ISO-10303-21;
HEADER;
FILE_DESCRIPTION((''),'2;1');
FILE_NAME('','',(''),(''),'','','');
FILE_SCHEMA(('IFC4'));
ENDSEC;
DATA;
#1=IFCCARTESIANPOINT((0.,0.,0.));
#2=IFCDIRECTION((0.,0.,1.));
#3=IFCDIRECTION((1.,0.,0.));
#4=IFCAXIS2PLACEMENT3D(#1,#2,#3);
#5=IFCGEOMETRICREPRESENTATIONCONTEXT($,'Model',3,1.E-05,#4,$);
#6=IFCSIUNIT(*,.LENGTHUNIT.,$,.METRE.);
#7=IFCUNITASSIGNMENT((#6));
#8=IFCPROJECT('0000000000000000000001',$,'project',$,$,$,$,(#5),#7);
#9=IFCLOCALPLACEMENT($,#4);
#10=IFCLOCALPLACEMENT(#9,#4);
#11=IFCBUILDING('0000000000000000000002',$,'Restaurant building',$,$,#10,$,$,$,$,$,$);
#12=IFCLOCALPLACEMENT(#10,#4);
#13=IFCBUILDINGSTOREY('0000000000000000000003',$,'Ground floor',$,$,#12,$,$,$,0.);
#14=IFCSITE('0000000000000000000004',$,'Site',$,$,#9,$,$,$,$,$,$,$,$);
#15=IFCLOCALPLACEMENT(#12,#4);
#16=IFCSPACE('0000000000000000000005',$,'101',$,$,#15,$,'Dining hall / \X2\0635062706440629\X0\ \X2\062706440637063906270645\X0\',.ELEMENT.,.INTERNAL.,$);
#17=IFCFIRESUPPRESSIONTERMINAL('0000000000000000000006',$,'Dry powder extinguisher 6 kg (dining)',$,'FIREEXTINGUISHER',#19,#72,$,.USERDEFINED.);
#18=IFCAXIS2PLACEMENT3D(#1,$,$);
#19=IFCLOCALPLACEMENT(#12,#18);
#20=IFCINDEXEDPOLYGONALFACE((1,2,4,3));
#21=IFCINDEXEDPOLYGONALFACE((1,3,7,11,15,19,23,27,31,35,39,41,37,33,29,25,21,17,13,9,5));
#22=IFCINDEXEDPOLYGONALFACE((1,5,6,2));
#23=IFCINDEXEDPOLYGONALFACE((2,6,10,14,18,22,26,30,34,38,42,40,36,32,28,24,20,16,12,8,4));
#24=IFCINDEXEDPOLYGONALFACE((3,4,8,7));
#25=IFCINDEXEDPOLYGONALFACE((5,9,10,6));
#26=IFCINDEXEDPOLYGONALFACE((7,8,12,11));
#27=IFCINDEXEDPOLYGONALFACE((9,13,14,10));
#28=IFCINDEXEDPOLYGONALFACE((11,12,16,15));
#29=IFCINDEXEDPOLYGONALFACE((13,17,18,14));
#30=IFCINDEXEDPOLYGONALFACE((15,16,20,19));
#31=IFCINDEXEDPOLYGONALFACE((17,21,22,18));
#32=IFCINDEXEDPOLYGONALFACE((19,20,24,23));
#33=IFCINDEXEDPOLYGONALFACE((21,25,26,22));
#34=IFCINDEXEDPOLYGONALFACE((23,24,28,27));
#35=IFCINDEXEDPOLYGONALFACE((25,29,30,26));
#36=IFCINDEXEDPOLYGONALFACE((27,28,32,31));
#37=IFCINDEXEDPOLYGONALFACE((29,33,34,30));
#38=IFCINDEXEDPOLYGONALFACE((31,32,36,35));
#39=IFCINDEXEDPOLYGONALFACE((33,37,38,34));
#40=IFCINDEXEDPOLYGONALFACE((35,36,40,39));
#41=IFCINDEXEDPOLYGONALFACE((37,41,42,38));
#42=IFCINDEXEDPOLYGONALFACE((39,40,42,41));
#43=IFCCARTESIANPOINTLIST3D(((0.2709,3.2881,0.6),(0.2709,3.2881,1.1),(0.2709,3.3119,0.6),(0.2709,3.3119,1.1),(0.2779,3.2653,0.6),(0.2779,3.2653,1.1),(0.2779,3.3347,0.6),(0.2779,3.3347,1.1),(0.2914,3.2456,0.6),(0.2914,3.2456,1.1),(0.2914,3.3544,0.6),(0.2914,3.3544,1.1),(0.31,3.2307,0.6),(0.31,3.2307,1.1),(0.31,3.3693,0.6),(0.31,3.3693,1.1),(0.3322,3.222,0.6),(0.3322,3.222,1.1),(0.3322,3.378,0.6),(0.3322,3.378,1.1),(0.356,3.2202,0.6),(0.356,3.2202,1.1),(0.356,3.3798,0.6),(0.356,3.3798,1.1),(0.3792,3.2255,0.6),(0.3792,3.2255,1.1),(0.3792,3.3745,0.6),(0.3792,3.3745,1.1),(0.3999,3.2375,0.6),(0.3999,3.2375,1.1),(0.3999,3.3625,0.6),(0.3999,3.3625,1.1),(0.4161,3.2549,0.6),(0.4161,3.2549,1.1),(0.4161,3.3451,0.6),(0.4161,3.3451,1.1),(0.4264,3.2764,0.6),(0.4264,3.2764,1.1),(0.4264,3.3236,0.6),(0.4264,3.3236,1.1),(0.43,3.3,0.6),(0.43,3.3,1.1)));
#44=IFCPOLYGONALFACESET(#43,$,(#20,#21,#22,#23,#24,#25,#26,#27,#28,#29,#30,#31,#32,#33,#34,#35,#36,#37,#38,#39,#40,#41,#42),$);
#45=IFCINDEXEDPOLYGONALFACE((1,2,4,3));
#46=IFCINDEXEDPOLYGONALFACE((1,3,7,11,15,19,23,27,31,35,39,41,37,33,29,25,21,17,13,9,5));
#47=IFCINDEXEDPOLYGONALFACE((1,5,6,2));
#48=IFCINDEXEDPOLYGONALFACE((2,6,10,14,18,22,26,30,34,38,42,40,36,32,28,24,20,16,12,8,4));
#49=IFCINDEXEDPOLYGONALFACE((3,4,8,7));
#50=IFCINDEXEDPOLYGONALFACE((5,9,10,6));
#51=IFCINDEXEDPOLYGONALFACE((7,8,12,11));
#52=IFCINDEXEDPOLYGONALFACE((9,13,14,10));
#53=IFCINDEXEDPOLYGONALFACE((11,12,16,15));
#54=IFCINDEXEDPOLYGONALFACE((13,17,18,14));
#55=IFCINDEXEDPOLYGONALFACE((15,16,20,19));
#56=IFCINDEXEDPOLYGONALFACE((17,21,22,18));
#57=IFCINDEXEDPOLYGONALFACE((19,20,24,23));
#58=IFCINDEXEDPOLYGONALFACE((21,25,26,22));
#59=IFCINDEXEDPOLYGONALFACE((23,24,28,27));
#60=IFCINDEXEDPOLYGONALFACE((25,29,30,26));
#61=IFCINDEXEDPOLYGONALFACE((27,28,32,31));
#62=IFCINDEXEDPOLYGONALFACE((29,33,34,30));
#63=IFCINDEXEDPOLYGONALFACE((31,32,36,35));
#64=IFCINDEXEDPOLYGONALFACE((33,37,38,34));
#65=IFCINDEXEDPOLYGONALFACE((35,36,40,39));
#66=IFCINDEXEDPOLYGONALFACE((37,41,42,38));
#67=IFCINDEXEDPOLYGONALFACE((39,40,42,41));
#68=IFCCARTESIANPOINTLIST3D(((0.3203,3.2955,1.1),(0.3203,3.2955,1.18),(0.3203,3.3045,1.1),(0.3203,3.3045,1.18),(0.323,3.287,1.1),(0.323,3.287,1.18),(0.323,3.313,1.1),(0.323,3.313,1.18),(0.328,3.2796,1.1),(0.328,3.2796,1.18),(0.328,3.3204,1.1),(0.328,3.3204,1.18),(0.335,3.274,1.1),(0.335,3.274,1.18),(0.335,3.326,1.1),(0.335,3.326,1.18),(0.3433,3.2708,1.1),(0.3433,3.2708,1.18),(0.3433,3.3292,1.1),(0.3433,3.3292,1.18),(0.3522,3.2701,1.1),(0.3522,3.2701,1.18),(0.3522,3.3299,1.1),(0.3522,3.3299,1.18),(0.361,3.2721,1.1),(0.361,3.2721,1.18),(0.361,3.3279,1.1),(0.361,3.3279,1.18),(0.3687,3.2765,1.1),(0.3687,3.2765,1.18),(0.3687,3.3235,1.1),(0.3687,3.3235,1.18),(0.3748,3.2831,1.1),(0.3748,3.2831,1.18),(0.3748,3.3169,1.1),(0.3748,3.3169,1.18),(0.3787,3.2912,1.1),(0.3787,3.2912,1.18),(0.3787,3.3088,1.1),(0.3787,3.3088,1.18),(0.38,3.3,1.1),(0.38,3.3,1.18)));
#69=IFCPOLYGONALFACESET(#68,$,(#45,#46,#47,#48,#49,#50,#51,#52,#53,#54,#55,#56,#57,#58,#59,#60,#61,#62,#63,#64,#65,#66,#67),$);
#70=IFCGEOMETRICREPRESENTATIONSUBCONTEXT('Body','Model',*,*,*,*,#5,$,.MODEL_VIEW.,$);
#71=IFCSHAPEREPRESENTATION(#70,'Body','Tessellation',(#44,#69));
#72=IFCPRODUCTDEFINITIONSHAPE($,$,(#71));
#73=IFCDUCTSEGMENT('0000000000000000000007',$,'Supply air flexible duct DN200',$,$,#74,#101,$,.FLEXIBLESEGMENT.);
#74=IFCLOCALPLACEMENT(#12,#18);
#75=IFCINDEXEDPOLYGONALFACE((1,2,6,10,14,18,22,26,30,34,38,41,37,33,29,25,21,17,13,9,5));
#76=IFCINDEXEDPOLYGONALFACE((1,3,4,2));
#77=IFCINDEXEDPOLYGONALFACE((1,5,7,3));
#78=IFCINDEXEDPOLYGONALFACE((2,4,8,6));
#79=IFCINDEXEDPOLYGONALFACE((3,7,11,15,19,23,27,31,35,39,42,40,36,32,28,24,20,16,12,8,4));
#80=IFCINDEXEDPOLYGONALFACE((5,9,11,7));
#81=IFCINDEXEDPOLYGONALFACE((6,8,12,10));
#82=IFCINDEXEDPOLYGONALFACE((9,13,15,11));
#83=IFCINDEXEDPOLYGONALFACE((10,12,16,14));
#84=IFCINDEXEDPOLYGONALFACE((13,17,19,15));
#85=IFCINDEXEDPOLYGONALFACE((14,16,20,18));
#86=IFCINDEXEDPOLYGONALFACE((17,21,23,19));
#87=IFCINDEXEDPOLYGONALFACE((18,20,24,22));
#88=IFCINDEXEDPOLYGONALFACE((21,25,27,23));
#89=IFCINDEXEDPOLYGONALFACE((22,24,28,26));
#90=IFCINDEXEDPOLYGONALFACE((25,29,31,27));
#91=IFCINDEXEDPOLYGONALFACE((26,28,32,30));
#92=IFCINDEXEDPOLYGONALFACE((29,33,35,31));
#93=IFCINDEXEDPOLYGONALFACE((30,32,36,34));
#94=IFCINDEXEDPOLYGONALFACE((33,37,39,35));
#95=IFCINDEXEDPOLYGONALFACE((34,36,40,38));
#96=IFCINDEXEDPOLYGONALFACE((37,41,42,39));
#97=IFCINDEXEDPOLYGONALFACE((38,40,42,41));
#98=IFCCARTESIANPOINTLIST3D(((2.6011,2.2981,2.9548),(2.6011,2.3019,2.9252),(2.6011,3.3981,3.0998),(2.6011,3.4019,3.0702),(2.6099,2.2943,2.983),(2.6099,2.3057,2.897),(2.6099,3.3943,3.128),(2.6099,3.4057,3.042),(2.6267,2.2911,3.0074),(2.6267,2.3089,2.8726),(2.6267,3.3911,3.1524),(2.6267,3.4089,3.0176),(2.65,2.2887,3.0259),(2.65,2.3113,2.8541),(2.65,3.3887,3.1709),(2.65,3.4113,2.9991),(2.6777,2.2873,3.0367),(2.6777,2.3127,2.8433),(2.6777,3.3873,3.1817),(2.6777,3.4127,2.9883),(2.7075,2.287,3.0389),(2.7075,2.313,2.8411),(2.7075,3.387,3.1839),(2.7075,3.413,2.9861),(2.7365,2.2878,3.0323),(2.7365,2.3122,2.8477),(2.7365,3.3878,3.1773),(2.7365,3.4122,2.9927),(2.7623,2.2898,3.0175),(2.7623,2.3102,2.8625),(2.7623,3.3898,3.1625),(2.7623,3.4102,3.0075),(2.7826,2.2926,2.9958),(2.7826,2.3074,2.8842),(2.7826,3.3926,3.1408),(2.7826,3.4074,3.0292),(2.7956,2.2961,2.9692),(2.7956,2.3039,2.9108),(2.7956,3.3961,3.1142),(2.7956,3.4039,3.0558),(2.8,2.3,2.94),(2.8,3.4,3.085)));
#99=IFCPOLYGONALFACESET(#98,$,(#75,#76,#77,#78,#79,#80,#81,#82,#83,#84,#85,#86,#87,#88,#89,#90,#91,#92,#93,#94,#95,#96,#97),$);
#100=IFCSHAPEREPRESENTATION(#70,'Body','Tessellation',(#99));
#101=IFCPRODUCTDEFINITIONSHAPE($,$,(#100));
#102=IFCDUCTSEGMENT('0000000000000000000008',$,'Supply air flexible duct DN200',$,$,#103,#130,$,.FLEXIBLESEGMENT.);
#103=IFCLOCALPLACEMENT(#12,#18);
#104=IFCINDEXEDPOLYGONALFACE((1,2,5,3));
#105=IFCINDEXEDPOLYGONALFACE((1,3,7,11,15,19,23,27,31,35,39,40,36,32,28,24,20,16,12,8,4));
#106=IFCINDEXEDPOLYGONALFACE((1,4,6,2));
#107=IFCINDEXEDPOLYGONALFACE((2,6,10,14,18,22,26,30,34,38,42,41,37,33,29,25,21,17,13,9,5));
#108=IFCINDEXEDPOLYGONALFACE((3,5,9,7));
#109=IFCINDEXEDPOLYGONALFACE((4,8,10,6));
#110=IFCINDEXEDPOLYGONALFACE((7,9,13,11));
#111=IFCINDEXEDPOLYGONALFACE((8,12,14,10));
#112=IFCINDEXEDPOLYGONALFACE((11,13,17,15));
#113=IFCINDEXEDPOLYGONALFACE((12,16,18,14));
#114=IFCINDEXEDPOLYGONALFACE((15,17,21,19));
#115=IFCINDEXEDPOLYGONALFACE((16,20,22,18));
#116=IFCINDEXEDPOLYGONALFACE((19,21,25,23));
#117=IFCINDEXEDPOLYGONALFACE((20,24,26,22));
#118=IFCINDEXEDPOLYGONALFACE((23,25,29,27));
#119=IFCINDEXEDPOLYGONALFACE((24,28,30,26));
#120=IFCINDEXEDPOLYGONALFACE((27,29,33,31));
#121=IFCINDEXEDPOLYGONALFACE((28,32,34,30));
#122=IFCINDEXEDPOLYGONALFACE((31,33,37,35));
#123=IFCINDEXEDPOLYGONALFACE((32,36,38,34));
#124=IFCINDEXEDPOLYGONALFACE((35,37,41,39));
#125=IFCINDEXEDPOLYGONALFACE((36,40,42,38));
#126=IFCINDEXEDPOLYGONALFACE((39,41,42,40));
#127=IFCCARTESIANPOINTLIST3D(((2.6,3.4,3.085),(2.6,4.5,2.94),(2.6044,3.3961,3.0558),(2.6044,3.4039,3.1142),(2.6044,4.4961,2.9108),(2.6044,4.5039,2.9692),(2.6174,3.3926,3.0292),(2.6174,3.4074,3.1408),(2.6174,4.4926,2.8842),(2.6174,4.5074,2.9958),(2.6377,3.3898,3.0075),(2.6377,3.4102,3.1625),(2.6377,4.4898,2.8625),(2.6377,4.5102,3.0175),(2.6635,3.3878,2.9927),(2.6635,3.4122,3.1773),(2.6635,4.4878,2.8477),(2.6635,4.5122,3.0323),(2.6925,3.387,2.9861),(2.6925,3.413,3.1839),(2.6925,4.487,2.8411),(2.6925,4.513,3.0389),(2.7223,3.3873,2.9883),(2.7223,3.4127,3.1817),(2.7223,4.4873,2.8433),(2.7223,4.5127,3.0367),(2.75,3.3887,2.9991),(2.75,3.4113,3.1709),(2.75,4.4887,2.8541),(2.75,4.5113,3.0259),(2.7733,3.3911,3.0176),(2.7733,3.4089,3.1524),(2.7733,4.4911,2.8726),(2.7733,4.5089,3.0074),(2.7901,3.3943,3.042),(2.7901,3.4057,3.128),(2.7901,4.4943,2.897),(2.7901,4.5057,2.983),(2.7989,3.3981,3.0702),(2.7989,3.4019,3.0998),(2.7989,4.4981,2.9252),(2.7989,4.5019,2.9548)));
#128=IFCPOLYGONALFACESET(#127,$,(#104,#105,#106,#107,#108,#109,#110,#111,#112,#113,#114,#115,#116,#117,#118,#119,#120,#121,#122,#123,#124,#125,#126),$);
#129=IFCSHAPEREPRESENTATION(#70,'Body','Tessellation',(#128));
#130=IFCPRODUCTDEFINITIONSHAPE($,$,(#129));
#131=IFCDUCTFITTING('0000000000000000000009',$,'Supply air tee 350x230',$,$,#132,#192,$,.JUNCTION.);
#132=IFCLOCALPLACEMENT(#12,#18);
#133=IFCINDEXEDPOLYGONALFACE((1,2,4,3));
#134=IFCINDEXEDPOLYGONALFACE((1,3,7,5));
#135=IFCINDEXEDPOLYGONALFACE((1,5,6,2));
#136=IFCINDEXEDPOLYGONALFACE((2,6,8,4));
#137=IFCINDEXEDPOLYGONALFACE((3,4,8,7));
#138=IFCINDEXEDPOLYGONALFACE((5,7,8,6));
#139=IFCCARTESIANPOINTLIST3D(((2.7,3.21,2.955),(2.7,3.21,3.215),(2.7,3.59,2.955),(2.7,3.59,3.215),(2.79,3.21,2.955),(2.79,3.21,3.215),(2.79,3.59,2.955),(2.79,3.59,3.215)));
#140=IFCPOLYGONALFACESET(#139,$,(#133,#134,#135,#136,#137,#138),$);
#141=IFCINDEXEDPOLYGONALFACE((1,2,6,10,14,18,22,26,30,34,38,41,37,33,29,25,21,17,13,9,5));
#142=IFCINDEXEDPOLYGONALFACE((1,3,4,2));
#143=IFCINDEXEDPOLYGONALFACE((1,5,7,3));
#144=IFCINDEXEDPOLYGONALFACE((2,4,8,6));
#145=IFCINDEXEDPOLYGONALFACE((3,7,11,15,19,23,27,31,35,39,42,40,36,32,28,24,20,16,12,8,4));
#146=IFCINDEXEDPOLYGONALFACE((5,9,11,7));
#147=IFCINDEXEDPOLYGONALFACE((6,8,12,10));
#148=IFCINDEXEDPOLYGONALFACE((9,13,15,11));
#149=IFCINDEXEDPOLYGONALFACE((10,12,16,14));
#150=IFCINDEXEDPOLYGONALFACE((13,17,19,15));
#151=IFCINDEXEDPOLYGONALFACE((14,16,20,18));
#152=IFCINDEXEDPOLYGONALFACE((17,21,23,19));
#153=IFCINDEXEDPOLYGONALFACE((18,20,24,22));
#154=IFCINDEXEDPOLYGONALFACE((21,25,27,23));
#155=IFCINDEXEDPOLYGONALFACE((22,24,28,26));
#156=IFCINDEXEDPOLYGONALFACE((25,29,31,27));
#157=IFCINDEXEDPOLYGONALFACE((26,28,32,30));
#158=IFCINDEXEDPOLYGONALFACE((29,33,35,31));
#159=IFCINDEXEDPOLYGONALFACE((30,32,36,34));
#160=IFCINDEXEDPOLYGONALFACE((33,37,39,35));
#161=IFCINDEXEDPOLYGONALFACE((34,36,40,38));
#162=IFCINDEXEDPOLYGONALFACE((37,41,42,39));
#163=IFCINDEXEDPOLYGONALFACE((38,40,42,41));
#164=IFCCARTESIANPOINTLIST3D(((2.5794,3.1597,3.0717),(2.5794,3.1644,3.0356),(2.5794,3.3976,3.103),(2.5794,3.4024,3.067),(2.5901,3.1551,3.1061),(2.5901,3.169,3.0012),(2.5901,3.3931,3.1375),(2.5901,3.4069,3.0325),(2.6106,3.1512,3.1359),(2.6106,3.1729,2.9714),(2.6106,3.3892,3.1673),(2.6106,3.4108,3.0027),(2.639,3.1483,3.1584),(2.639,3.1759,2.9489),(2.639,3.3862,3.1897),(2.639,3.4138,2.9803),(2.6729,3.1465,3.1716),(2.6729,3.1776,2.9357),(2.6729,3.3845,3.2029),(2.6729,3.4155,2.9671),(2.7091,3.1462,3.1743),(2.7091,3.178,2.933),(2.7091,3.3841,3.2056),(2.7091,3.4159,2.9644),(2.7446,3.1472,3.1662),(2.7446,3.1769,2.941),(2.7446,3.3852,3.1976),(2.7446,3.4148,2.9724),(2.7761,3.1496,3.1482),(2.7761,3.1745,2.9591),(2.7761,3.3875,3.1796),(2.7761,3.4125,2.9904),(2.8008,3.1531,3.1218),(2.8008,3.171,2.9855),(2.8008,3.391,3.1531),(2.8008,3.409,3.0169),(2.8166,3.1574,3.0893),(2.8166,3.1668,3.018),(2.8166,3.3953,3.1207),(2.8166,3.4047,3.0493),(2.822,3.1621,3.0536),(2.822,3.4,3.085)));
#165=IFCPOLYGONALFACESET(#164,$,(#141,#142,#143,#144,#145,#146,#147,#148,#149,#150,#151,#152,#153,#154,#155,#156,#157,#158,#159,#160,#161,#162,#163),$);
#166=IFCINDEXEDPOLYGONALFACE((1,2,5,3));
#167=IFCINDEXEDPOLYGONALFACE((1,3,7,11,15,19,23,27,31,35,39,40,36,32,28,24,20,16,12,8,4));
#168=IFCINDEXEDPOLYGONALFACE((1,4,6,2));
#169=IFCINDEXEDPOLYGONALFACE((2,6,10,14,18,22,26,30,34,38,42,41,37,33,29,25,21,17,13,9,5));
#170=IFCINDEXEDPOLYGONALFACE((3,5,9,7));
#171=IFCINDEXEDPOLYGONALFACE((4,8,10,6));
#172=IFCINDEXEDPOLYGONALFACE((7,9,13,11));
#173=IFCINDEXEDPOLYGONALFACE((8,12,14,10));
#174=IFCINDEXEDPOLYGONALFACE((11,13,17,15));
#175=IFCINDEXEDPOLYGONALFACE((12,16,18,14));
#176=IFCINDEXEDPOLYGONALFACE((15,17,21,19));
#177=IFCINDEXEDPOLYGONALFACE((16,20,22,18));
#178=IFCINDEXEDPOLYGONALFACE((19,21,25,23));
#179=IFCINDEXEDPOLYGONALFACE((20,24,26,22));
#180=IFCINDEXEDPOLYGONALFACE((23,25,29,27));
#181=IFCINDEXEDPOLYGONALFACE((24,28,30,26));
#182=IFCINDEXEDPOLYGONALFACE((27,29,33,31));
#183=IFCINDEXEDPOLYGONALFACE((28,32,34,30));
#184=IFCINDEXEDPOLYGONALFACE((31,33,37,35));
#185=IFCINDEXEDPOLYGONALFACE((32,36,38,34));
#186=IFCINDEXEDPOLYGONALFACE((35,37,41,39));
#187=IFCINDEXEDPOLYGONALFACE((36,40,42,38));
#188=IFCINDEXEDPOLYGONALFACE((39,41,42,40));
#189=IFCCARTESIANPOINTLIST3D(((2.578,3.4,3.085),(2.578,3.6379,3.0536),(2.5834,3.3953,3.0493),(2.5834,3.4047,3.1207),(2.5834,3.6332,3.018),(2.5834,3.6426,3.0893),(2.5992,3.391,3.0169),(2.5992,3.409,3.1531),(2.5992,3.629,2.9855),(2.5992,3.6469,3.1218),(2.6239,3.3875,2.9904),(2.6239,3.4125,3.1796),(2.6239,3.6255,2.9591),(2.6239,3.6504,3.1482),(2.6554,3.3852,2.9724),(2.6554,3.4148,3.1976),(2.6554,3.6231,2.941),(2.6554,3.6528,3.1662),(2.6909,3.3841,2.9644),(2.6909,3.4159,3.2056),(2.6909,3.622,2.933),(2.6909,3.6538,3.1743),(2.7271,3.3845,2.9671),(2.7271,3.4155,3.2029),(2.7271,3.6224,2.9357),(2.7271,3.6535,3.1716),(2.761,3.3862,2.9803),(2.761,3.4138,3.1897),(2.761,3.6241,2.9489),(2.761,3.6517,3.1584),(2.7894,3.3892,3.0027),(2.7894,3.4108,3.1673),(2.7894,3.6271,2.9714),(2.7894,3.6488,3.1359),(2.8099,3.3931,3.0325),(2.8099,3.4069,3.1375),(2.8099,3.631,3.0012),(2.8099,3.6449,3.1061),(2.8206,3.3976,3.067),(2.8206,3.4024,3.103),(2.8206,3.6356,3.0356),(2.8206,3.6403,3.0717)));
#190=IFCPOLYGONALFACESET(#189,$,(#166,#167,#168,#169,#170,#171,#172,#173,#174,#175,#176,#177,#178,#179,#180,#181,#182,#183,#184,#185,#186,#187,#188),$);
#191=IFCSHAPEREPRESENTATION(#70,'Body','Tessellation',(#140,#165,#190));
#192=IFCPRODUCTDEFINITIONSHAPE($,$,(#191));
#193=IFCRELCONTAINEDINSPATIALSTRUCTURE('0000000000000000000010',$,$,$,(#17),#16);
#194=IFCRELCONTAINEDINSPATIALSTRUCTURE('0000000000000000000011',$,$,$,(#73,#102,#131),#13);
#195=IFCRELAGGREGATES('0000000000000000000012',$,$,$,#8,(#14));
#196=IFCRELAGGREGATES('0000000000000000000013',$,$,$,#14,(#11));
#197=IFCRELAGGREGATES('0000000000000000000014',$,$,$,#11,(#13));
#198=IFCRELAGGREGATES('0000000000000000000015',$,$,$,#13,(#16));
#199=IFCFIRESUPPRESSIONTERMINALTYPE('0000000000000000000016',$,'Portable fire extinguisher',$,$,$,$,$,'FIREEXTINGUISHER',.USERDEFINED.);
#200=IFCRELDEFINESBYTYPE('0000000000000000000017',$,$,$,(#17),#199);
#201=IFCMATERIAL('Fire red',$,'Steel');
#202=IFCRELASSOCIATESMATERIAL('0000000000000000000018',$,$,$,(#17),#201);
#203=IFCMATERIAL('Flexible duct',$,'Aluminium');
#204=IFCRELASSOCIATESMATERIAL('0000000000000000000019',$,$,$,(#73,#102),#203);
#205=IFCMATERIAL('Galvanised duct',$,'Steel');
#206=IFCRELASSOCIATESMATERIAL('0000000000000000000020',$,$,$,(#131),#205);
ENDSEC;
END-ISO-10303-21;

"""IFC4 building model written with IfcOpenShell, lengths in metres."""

from ifc_helpers import new_model, si_unit, frame, origin, origin_with_axes, origin_2d, place, context, subcontext, project, spatial, rectangle, circle, extrude, source, transform, mapped, material, type_object, type_shapes, element, save


model = new_model("IFC4")

# Units and contexts
model_context = context("Model", 3, precision=1e-05, world=origin_with_axes())
body_context = subcontext(model_context, "Body", "Model", "MODEL_VIEW")
ifc_project = project(units=[si_unit("LENGTHUNIT", "METRE")], contexts=[model_context])

# Site, building, storey
site_placement = place(None, origin_with_axes())
site = spatial("IfcSite", under=ifc_project, at=site_placement, Name="Site")
building_placement = place(site_placement, origin_with_axes())
building = spatial("IfcBuilding", under=site, at=building_placement, Name="Restaurant building")
storey_placement = place(building_placement, origin_with_axes())
storey = spatial("IfcBuildingStorey", under=building, at=storey_placement, Name="Ground floor", Elevation=0.0)

# Shared definitions
space_placement = place(storey_placement, origin_with_axes())
space = spatial("IfcSpace", under=storey, at=space_placement, Name="101", LongName="Dining hall / صالة الطعام", CompositionType="ELEMENT", PredefinedType="INTERNAL")

# Fire suppression terminal
ifc_material_1 = material(Name="Fire red", Category="Steel")
fire_suppression_terminal_type_1 = type_object("IfcFireSuppressionTerminalType", Name="Portable fire extinguisher", ElementType="FIREEXTINGUISHER", PredefinedType="USERDEFINED")
shared_shape_1 = source(origin(), body_context, "Body", "SweptSolid", [
    extrude(circle(Radius=0.08, at=origin_2d()), origin(), (0.0, 0.0, 1.0), 0.5),
    extrude(circle(Radius=0.03, at=origin_2d()), frame((0.0, 0.0, 0.5)), (0.0, 0.0, 1.0), 0.08),
])
type_shapes(fire_suppression_terminal_type_1, [shared_shape_1])
fire_suppression_terminal_1_placement = place(storey_placement, frame((0.35, 3.3, 0.6)))
element("IfcFireSuppressionTerminal", 1, at=fire_suppression_terminal_1_placement, inside=space, type_object=fire_suppression_terminal_type_1, material=ifc_material_1, Name="Dry powder extinguisher 6 kg (dining)", ObjectType="FIREEXTINGUISHER", PredefinedType="USERDEFINED", context=body_context, shape_type="MappedRepresentation", body=[
    mapped(shared_shape_1, transform((0.0, 0.0, 0.0))),
])

# Duct segments
ifc_material_2 = material(Name="Flexible duct", Category="Aluminium")
duct_segment_1_placement = place(storey_placement, frame((2.7, 3.4, 3.085)))
element("IfcDuctSegment", 2, at=duct_segment_1_placement, inside=storey, material=ifc_material_2, Name="Supply air flexible duct DN200", PredefinedType="FLEXIBLESEGMENT", context=body_context, shape_type="SweptSolid", body=[
    extrude(circle(Radius=0.1, at=origin_2d()), frame((0.0, 0.0, 0.0), z_axis=(0.0, -0.991424, -0.130688), x_axis=(1.0, 0.0, 0.0)), (0.0, 0.0, 1.0), 1.1095),
])
duct_segment_2_placement = place(storey_placement, frame((2.7, 3.4, 3.085)))
element("IfcDuctSegment", 3, at=duct_segment_2_placement, inside=storey, material=ifc_material_2, Name="Supply air flexible duct DN200", PredefinedType="FLEXIBLESEGMENT", context=body_context, shape_type="SweptSolid", body=[
    extrude(circle(Radius=0.1, at=origin_2d()), frame((0.0, 0.0, 0.0), z_axis=(0.0, 0.991424, -0.130688), x_axis=(-1.0, 0.0, 0.0)), (0.0, 0.0, 1.0), 1.1095),
])

# Duct fitting
ifc_material_3 = material(Name="Galvanised duct", Category="Steel")
duct_fitting_placement = place(storey_placement, frame((2.7, 3.4, 3.085)))
element("IfcDuctFitting", 4, at=duct_fitting_placement, inside=storey, material=ifc_material_3, Name="Supply air tee 350x230", PredefinedType="JUNCTION", context=body_context, shape_type="SweptSolid", body=[
    extrude(rectangle(XDim=0.38, YDim=0.26, at=origin_2d()), frame((0.0, 0.0, 0.0), z_axis=(1.0, 0.0, 0.0), x_axis=(0.0, 1.0, 0.0)), (0.0, 0.0, 1.0), 0.09),
    extrude(circle(Radius=0.122, at=origin_2d()), frame((0.0, 0.0, 0.0), z_axis=(0.0, -0.991424, -0.130688), x_axis=(1.0, 0.0, 0.0)), (0.0, 0.0, 1.0), 0.24),
    extrude(circle(Radius=0.122, at=origin_2d()), frame((0.0, 0.0, 0.0), z_axis=(0.0, 0.991424, -0.130688), x_axis=(-1.0, 0.0, 0.0)), (0.0, 0.0, 1.0), 0.24),
])

save(model, "model.ifc")
